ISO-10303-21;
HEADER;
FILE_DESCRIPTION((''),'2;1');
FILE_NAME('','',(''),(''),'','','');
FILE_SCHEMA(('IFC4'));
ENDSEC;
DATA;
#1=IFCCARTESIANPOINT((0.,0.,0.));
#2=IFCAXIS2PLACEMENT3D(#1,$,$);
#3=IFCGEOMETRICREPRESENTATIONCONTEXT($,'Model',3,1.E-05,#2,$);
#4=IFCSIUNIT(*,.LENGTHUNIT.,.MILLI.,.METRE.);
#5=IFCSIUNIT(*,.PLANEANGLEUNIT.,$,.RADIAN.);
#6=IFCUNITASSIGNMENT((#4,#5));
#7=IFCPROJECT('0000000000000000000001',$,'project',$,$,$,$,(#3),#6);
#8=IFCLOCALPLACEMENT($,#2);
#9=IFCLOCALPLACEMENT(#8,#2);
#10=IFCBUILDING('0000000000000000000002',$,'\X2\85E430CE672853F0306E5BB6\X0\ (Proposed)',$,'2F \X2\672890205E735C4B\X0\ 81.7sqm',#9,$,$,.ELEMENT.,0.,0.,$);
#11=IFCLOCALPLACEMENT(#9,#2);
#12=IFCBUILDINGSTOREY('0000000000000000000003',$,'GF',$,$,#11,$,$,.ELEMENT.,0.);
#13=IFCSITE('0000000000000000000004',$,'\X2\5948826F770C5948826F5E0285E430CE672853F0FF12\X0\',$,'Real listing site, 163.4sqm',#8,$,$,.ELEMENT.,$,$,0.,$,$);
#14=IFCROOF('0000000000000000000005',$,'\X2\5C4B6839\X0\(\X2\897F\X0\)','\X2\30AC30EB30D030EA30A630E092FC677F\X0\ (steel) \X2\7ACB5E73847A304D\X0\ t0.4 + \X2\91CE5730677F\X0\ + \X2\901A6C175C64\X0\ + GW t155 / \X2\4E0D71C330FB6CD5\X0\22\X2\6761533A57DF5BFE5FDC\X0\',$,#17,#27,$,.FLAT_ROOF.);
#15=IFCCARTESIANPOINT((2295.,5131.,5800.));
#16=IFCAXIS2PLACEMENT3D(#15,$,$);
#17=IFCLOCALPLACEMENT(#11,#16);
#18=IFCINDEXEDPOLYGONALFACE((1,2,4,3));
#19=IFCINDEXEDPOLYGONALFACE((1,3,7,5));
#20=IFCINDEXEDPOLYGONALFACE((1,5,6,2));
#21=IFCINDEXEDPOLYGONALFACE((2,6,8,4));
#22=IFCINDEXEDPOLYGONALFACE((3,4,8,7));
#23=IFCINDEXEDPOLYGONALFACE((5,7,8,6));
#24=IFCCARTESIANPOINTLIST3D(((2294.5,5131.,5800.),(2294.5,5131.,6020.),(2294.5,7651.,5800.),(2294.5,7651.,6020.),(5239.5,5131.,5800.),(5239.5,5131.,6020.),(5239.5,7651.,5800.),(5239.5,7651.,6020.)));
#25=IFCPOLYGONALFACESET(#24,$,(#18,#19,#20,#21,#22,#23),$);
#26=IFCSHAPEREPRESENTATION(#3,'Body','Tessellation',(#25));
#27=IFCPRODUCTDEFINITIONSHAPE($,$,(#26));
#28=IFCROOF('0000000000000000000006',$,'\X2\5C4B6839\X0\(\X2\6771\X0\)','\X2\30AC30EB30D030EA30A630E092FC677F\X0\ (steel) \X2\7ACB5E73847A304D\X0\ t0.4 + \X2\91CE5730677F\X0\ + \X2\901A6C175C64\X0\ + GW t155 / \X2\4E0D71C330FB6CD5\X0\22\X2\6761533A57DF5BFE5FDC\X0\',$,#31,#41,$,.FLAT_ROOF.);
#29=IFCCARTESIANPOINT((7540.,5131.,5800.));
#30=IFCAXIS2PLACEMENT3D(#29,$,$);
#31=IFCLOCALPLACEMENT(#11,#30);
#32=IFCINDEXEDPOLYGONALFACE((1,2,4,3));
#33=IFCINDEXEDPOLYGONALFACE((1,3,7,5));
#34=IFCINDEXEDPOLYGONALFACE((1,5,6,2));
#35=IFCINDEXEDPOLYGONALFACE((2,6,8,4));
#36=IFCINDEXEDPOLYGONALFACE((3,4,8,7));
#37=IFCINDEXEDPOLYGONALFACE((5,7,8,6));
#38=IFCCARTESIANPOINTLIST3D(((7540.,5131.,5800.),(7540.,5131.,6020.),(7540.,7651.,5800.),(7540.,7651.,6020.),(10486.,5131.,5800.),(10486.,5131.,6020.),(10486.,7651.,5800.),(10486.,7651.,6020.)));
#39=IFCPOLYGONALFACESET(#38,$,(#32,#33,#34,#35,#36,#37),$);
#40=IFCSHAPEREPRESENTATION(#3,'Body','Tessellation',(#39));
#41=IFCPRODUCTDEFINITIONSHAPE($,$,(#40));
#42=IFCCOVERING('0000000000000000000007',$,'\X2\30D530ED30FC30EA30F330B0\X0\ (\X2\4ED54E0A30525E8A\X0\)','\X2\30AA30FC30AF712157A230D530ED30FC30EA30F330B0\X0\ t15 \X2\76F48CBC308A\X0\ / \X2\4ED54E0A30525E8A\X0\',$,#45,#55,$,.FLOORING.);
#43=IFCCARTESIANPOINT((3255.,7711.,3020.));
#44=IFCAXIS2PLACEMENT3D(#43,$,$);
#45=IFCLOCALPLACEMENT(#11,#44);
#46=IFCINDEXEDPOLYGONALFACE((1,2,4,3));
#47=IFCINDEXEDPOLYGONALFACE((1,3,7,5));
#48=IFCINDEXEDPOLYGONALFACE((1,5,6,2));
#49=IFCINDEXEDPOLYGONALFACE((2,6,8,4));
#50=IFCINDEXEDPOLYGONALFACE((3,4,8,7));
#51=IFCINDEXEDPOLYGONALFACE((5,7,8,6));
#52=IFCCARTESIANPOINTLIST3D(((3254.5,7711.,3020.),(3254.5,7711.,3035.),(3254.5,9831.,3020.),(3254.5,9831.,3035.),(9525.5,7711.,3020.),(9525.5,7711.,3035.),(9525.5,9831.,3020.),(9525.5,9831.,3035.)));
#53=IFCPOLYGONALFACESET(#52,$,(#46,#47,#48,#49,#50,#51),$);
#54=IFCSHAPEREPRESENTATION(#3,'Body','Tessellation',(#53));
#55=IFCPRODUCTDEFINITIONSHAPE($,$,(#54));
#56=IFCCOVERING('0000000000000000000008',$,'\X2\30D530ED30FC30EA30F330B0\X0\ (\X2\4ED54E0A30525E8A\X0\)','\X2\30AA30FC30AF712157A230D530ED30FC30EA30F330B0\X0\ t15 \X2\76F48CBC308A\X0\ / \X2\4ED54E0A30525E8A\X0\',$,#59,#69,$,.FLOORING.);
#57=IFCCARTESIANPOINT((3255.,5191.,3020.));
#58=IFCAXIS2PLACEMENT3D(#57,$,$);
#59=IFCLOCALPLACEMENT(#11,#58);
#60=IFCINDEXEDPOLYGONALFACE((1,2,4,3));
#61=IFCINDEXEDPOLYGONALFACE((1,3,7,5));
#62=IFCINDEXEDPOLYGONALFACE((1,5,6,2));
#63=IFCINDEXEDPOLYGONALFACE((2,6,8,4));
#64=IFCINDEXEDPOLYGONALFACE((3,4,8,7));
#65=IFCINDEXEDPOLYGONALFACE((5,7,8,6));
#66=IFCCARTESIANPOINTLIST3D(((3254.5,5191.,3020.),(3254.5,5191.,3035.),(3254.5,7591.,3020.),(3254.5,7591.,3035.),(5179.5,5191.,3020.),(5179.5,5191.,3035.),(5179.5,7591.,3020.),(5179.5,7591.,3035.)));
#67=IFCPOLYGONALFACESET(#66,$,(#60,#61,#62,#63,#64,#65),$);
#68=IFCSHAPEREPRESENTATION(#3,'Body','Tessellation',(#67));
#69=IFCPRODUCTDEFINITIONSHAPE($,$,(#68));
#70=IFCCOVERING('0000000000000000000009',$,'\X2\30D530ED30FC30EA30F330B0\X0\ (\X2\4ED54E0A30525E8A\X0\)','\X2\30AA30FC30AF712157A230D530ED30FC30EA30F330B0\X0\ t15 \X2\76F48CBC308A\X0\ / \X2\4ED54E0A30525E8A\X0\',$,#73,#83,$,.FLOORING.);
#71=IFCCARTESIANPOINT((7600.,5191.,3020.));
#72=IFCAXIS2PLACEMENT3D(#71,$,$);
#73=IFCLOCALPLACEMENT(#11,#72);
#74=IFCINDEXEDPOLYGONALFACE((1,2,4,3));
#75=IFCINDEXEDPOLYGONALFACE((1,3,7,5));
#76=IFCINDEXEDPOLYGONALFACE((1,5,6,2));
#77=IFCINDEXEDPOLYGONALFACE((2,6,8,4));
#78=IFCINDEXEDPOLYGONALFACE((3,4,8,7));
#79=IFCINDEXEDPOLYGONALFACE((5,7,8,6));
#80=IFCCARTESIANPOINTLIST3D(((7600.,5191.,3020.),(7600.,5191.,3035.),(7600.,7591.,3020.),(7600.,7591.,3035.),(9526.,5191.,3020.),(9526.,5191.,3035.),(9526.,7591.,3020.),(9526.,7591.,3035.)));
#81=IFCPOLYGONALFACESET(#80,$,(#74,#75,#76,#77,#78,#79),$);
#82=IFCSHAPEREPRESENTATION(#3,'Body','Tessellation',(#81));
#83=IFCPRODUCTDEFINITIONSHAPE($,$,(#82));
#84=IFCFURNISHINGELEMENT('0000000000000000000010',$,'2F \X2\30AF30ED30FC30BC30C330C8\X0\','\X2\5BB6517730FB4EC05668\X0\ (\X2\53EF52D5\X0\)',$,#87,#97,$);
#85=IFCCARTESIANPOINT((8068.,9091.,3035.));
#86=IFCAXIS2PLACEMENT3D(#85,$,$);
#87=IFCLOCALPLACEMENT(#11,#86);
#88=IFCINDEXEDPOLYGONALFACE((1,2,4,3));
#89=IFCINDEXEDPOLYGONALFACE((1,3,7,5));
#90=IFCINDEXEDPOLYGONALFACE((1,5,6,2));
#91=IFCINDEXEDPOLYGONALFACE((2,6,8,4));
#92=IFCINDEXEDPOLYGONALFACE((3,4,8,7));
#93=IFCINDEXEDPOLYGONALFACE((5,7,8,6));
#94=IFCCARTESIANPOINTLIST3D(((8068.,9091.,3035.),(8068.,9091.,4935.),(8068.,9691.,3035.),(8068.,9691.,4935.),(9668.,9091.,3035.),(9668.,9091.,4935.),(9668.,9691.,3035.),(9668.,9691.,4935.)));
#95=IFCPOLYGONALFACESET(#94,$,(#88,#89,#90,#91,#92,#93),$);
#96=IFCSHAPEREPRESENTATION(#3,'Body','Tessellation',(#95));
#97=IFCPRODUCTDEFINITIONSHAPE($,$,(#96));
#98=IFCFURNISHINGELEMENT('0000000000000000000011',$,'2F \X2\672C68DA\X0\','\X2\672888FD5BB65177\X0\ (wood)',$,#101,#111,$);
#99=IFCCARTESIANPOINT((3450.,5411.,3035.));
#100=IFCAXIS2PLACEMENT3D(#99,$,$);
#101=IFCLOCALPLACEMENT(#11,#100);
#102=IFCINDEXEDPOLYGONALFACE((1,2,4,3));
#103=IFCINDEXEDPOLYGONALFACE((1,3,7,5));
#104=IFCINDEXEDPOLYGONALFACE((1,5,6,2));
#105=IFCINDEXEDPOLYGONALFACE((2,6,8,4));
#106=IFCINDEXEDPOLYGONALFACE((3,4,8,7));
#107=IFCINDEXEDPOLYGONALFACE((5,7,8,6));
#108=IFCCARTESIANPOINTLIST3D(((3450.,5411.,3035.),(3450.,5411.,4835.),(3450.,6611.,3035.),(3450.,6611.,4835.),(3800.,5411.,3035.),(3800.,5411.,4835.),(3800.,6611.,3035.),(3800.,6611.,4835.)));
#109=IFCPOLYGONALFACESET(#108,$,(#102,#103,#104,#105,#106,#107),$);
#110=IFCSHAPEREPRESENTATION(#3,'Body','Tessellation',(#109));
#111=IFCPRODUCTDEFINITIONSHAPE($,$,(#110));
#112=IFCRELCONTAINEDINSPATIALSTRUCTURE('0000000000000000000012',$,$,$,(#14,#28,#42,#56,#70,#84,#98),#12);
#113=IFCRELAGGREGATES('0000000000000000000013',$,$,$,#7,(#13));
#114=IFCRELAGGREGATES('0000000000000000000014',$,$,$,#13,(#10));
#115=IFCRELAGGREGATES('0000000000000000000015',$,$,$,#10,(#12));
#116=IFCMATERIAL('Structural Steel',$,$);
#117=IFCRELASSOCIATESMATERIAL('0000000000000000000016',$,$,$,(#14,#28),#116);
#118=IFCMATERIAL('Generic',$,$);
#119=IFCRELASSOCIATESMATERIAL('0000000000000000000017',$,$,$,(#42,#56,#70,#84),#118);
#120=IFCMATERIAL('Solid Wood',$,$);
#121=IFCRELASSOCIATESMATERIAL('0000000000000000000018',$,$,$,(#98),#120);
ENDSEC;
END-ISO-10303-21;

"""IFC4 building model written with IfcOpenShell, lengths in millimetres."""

from ifc_helpers import new_model, si_unit, frame, frame_2d, origin, place, context, project, spatial, rectangle, extrude, material, element, save


model = new_model("IFC4")

# Units and contexts
model_context = context("Model", 3, precision=1e-05, world=origin())
ifc_project = project(units=[si_unit("LENGTHUNIT", "METRE", prefix="MILLI"), si_unit("PLANEANGLEUNIT", "RADIAN")], contexts=[model_context])

# Site, building, storey
site_placement = place(None, origin())
site = spatial("IfcSite", under=ifc_project, at=site_placement, Name="奈良県奈良市藤ノ木台２", ObjectType="Real listing site, 163.4sqm", CompositionType="ELEMENT", RefElevation=0.0)
building_placement = place(site_placement, origin())
building = spatial("IfcBuilding", under=site, at=building_placement, Name="藤ノ木台の家 (Proposed)", ObjectType="2F 木造平屋 81.7sqm", CompositionType="ELEMENT", ElevationOfRefHeight=0.0, ElevationOfTerrain=0.0)
storey_placement = place(building_placement, origin())
storey = spatial("IfcBuildingStorey", under=building, at=storey_placement, Name="GF", CompositionType="ELEMENT", Elevation=0.0)

# Shared definitions
ifc_material_1 = material(Name="Solid Wood")

# Roofs
ifc_material_2 = material(Name="Structural Steel")
roof_1_placement = place(storey_placement, frame((2295.0, 5131.0, 5800.0)))
element("IfcRoof", 1, at=roof_1_placement, inside=storey, material=ifc_material_2, Name="屋根(西)", Description="ガルバリウム鋼板 (steel) 立平葺き t0.4 + 野地板 + 通気層 + GW t155 / 不燃・法22条区域対応", PredefinedType="FLAT_ROOF", context=model_context, shape_type="SweptSolid", body=[
    extrude(rectangle(XDim=2945.0, YDim=2520.0, at=frame_2d((1472.0, 1260.0))), frame((2295.0, 5131.0, 5800.0)), (0.0, 0.0, 1.0), 220.0),
])
roof_2_placement = place(storey_placement, frame((7540.0, 5131.0, 5800.0)))
element("IfcRoof", 2, at=roof_2_placement, inside=storey, material=ifc_material_2, Name="屋根(東)", Description="ガルバリウム鋼板 (steel) 立平葺き t0.4 + 野地板 + 通気層 + GW t155 / 不燃・法22条区域対応", PredefinedType="FLAT_ROOF", context=model_context, shape_type="SweptSolid", body=[
    extrude(rectangle(XDim=2946.0, YDim=2520.0, at=frame_2d((1473.0, 1260.0))), frame((7540.0, 5131.0, 5800.0)), (0.0, 0.0, 1.0), 220.0),
])

# Coverings
ifc_material_3 = material(Name="Generic")
covering_1_placement = place(storey_placement, frame((3255.0, 7711.0, 3020.0)))
element("IfcCovering", 3, at=covering_1_placement, inside=storey, material=ifc_material_3, Name="フローリング (仕上げ床)", Description="オーク無垢フローリング t15 直貼り / 仕上げ床", PredefinedType="FLOORING", context=model_context, shape_type="SweptSolid", body=[
    extrude(rectangle(XDim=6271.0, YDim=2120.0, at=frame_2d((3135.0, 1060.0))), frame((3255.0, 7711.0, 3020.0)), (0.0, 0.0, 1.0), 15.0),
])
covering_2_placement = place(storey_placement, frame((3255.0, 5191.0, 3020.0)))
element("IfcCovering", 4, at=covering_2_placement, inside=storey, material=ifc_material_3, Name="フローリング (仕上げ床)", Description="オーク無垢フローリング t15 直貼り / 仕上げ床", PredefinedType="FLOORING", context=model_context, shape_type="SweptSolid", body=[
    extrude(rectangle(XDim=1925.0, YDim=2400.0, at=frame_2d((962.0, 1200.0))), frame((3255.0, 5191.0, 3020.0)), (0.0, 0.0, 1.0), 15.0),
])
covering_3_placement = place(storey_placement, frame((7600.0, 5191.0, 3020.0)))
element("IfcCovering", 5, at=covering_3_placement, inside=storey, material=ifc_material_3, Name="フローリング (仕上げ床)", Description="オーク無垢フローリング t15 直貼り / 仕上げ床", PredefinedType="FLOORING", context=model_context, shape_type="SweptSolid", body=[
    extrude(rectangle(XDim=1926.0, YDim=2400.0, at=frame_2d((963.0, 1200.0))), frame((7600.0, 5191.0, 3020.0)), (0.0, 0.0, 1.0), 15.0),
])

# Furnishing elements
furnishing_1_placement = place(storey_placement, frame((8068.0, 9091.0, 3035.0)))
element("IfcFurnishingElement", 6, at=furnishing_1_placement, inside=storey, material=ifc_material_3, Name="2F クローゼット", Description="家具・什器 (可動)", context=model_context, shape_type="SweptSolid", body=[
    extrude(rectangle(XDim=1600.0, YDim=600.0, at=frame_2d((800.0, 300.0))), frame((8068.0, 9091.0, 3035.0)), (0.0, 0.0, 1.0), 1900.0),
])
furnishing_2_placement = place(storey_placement, frame((3450.0, 5411.0, 3035.0)))
element("IfcFurnishingElement", 7, at=furnishing_2_placement, inside=storey, material=ifc_material_1, Name="2F 本棚", Description="木製家具 (wood)", context=model_context, shape_type="SweptSolid", body=[
    extrude(rectangle(XDim=350.0, YDim=1200.0, at=frame_2d((175.0, 600.0))), frame((3450.0, 5411.0, 3035.0)), (0.0, 0.0, 1.0), 1800.0),
])

save(model, "model.ifc")
